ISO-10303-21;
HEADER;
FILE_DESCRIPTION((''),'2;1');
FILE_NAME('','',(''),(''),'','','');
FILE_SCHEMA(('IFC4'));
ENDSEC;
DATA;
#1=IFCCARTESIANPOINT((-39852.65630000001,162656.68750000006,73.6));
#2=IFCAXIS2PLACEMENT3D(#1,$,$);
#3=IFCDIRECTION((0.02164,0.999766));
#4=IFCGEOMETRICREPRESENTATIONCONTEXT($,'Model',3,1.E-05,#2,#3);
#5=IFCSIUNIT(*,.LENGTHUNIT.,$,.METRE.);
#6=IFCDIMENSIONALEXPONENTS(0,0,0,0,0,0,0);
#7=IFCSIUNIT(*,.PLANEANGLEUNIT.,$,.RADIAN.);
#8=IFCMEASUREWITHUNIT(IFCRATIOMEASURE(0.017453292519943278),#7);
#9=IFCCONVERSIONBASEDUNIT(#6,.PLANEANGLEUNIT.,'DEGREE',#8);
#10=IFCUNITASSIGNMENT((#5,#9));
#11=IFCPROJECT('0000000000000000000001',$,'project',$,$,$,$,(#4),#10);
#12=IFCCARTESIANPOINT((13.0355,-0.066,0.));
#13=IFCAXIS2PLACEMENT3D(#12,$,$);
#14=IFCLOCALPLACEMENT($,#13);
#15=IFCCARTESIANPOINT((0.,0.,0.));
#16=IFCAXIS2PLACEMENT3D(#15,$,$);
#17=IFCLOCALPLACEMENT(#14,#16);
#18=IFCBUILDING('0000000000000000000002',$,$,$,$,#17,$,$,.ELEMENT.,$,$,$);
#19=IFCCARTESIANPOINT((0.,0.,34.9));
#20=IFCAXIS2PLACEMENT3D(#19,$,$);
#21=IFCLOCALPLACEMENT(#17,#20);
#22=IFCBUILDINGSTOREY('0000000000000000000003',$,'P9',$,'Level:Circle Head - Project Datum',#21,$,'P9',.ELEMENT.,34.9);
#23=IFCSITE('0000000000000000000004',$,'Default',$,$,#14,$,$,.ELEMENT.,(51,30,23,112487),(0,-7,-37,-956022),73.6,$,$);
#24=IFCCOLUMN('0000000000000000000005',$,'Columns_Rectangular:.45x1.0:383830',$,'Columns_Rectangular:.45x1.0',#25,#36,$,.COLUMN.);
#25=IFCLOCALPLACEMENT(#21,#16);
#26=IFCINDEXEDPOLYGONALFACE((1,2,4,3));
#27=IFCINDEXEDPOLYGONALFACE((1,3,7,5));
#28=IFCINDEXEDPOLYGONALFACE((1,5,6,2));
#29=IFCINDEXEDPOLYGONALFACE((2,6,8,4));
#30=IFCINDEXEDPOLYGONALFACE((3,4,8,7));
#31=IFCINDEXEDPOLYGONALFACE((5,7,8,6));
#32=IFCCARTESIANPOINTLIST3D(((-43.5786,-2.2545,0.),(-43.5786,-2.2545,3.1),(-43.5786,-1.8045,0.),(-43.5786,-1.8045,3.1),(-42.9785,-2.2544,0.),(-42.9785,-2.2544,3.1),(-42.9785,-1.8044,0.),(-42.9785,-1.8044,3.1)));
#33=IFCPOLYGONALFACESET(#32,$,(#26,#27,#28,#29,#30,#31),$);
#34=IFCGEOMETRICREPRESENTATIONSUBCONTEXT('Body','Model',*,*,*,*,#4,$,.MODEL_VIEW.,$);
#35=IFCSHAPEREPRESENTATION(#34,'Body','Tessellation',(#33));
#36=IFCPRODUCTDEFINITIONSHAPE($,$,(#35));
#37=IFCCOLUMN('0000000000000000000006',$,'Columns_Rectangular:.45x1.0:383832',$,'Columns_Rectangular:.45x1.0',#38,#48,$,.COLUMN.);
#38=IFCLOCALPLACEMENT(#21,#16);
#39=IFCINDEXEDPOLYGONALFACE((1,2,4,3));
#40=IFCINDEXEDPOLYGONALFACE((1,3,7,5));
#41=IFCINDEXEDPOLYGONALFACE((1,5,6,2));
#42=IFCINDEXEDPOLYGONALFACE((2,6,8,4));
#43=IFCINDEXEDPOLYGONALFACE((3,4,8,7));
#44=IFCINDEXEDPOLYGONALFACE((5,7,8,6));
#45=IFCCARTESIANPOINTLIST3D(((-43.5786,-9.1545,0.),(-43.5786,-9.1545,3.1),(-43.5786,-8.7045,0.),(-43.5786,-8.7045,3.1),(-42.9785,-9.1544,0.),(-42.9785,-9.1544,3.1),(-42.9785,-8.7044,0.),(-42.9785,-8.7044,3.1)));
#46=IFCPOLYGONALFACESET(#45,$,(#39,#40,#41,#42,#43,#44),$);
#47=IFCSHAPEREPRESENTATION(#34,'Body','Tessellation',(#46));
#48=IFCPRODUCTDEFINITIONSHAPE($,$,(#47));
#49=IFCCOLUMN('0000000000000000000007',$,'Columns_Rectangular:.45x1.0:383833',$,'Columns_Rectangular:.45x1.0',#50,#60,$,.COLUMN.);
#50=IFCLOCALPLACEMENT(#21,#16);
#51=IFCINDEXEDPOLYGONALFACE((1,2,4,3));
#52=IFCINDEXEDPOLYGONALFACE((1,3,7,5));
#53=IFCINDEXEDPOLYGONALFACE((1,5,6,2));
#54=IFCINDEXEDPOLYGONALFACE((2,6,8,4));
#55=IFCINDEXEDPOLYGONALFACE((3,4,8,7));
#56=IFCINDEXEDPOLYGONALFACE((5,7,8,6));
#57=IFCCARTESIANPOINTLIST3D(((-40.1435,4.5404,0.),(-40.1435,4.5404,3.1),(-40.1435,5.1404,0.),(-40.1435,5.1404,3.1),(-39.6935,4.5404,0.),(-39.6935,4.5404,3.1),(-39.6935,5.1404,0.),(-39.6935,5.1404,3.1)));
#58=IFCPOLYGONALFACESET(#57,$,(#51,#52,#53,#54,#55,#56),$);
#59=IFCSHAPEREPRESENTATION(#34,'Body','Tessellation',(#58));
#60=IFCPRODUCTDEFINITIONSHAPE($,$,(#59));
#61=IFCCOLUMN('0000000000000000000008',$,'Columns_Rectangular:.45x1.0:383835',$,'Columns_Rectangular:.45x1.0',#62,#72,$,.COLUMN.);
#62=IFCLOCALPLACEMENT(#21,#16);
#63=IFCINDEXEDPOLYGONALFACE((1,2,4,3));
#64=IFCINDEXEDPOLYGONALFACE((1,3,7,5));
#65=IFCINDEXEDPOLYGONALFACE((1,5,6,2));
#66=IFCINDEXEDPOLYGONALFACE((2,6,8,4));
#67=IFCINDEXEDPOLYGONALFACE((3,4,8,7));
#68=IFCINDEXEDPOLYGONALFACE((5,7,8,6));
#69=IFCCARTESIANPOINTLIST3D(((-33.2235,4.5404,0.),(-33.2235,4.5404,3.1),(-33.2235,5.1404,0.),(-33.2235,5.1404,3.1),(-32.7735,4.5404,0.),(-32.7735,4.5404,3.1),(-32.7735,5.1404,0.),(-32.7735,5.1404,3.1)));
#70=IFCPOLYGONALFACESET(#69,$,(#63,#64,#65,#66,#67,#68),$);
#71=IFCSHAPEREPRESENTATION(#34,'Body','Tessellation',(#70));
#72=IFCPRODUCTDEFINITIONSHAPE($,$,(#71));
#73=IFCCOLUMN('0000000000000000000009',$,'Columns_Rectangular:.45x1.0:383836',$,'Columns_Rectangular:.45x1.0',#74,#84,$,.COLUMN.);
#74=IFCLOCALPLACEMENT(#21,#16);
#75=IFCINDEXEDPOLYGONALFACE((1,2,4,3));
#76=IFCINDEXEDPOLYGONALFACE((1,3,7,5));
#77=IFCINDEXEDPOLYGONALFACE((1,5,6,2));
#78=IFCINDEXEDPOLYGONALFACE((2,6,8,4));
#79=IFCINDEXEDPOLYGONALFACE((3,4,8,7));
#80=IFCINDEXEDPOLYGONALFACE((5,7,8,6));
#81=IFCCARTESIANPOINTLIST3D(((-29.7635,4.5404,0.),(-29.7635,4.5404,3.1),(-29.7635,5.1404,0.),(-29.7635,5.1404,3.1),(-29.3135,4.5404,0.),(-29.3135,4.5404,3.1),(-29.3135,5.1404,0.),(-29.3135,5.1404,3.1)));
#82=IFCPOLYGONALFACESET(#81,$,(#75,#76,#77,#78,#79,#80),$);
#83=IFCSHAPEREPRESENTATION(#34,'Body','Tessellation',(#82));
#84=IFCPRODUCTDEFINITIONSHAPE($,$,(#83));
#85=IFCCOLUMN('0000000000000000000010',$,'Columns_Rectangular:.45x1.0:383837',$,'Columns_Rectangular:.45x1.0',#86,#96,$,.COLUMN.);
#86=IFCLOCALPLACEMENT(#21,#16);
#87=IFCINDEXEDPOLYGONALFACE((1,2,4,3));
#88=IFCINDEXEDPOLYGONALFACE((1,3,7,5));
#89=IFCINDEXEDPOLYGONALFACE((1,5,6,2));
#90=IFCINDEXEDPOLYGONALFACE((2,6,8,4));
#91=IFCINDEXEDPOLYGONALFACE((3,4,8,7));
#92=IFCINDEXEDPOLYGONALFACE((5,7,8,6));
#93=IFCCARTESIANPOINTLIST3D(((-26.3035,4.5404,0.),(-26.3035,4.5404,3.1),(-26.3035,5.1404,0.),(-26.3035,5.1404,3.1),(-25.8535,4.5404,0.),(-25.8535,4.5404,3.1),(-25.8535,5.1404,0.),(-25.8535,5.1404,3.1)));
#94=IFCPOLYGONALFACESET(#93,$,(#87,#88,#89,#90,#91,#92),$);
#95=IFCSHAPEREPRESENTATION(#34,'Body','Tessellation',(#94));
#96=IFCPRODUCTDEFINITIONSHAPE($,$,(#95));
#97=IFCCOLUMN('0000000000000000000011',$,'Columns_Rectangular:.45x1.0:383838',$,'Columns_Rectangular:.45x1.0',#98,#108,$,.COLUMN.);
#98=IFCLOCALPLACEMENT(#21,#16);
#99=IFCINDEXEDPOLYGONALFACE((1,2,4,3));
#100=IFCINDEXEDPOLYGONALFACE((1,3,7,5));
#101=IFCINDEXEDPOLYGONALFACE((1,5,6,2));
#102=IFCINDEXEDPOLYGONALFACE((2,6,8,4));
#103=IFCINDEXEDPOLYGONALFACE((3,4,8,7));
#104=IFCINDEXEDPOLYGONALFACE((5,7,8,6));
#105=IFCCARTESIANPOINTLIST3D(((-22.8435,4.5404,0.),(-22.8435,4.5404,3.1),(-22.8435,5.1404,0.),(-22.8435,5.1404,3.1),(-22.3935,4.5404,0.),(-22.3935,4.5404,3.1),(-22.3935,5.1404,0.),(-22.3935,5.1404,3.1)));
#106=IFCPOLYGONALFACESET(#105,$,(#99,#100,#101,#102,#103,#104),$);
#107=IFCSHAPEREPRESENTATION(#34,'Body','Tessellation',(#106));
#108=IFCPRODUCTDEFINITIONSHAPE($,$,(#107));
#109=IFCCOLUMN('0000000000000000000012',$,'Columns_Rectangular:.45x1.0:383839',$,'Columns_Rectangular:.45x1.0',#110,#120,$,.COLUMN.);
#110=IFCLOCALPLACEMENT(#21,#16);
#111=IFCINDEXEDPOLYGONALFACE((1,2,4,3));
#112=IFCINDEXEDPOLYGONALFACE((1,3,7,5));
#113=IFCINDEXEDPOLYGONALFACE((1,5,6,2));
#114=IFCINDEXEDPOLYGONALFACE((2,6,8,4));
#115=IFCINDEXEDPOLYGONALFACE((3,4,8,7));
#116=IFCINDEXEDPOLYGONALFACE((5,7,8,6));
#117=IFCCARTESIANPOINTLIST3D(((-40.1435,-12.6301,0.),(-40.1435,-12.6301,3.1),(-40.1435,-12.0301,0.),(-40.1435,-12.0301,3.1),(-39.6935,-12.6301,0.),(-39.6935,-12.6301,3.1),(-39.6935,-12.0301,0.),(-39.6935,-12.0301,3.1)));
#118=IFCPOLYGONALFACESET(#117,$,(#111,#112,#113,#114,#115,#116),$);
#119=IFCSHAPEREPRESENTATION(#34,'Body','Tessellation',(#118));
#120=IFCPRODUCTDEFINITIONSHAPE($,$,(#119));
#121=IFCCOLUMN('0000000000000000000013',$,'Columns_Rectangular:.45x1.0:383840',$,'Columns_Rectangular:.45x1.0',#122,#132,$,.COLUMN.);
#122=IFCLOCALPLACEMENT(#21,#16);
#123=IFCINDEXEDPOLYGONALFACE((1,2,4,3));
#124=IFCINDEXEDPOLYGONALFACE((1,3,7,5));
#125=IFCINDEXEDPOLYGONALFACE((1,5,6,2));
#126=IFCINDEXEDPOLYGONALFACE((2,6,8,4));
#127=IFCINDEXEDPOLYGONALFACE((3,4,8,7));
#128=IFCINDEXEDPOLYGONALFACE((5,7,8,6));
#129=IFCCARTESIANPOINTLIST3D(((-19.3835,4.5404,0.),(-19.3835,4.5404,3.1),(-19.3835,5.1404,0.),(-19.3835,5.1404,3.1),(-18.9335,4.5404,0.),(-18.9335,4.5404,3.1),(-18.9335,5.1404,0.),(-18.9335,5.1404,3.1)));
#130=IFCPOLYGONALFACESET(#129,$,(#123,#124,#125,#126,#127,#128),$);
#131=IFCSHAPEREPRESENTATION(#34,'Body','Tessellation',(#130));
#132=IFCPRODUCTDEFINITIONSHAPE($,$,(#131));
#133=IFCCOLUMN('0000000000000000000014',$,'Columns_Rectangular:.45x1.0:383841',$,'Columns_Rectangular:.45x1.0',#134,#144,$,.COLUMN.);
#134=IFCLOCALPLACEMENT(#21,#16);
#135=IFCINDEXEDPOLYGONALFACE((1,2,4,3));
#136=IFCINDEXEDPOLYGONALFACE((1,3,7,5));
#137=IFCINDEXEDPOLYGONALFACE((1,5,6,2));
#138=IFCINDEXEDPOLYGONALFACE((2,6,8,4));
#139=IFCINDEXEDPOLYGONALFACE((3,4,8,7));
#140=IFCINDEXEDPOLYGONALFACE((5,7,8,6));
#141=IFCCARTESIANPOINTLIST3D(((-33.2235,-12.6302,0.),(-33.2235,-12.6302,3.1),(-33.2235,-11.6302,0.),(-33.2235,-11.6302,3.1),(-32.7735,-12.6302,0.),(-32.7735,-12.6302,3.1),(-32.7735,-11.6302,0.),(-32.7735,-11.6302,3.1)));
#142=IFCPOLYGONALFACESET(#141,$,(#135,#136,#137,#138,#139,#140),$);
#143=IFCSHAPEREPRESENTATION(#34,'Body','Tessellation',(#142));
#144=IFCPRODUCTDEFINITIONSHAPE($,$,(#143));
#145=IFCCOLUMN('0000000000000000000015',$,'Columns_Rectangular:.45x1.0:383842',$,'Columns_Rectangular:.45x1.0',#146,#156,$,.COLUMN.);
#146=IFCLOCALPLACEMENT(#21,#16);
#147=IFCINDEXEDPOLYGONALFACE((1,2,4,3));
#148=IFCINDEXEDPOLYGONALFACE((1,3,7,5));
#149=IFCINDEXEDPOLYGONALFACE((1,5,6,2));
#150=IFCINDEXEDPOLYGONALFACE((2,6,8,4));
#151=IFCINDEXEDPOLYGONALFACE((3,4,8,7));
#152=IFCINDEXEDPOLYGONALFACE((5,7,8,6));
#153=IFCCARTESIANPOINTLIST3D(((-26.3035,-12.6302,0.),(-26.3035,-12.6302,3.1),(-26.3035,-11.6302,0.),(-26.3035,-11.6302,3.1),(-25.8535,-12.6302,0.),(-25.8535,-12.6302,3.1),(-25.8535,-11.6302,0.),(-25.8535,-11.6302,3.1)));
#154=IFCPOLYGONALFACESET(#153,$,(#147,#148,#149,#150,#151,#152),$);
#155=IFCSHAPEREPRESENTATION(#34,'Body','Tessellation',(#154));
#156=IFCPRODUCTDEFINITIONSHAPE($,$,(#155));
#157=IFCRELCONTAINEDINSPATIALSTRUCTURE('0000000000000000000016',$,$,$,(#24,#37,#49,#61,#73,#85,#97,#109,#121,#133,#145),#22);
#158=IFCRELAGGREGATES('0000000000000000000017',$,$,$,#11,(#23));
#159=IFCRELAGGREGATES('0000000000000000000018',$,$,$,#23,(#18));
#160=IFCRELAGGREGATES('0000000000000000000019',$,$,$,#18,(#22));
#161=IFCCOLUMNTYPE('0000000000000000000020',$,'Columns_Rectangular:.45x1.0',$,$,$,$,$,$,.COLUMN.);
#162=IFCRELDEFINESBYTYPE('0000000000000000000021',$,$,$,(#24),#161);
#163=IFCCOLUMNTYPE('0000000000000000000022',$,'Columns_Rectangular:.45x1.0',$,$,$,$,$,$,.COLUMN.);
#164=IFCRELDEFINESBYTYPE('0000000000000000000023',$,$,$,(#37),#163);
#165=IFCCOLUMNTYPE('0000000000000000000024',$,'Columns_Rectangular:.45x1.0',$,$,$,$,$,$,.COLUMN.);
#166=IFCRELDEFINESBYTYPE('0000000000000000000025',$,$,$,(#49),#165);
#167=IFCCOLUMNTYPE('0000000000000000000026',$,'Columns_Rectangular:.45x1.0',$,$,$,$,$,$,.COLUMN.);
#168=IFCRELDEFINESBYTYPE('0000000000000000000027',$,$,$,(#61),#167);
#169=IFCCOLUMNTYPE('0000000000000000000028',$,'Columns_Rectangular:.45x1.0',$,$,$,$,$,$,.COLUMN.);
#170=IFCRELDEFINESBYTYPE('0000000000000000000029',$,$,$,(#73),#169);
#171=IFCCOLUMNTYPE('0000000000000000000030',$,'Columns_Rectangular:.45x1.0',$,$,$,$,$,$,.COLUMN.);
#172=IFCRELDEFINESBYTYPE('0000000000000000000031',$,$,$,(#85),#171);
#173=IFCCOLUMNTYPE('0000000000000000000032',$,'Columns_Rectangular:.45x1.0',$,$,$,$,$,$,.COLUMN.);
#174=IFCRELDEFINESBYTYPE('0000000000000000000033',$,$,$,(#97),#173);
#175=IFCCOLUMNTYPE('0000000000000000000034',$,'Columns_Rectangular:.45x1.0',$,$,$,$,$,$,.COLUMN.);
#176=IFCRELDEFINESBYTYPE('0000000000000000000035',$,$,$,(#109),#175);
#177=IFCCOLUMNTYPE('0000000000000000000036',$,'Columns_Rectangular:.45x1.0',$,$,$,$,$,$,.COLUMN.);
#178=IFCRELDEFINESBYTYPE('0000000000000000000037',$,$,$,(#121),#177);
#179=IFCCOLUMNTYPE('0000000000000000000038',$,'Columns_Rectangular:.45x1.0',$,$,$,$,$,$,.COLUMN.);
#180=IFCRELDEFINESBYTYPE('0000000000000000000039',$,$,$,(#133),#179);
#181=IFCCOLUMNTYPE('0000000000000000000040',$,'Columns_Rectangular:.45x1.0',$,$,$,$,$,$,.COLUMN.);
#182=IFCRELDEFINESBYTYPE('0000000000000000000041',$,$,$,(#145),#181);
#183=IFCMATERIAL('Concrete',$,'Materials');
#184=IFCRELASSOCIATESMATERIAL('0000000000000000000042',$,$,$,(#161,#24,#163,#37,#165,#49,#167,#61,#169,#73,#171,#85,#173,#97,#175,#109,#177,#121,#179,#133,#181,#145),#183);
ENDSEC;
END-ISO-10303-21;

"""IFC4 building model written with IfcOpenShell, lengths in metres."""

from ifc_helpers import new_model, entity, si_unit, converted_unit, direction, frame, origin, place, context, subcontext, project, spatial, indexed_curve, outline, extrude, source, transform, mapped, material, type_object, type_shapes, element, save


model = new_model("IFC4")

# Units and contexts
model_context = context("Model", 3, precision=1e-05, world=frame((-39852.65630000001, 162656.68750000006, 73.6)), true_north=direction((0.02164, 0.999766)))
body_context = subcontext(model_context, "Body", "Model", "MODEL_VIEW")
ifc_project = project(units=[si_unit("LENGTHUNIT", "METRE"), converted_unit("PLANEANGLEUNIT", "DEGREE", entity("IfcRatioMeasure", 0.017453292519943278), si_unit("PLANEANGLEUNIT", "RADIAN"), dimensions=[0, 0, 0, 0, 0, 0, 0])], contexts=[model_context])

# Site, building, storey
site_placement = place(None, frame((13.0355, -0.066, 0.0)))
site = spatial("IfcSite", under=ifc_project, at=site_placement, Name="Default", CompositionType="ELEMENT", RefLatitude=(51, 30, 23, 112487), RefLongitude=(0, -7, -37, -956022), RefElevation=73.6)
building_placement = place(site_placement, origin())
building = spatial("IfcBuilding", under=site, at=building_placement, CompositionType="ELEMENT")
storey_placement = place(building_placement, frame((0.0, 0.0, 34.9)))
storey = spatial("IfcBuildingStorey", under=building, at=storey_placement, Name="P9", ObjectType="Level:Circle Head - Project Datum", LongName="P9", CompositionType="ELEMENT", Elevation=34.9)

# Columns
ifc_material = material(Name="Concrete", Category="Materials")
column_type_1 = type_object("IfcColumnType", Name="Columns_Rectangular:.45x1.0", PredefinedType="COLUMN", material=ifc_material)
shared_shape_1 = source(origin(), body_context, "Body", "SweptSolid", [
    extrude(outline(indexed_curve([(-0.3, -0.225), (0.3, -0.225), (0.3, 0.225), (-0.3, 0.225), (-0.3, -0.225)], self_intersect=False)), frame((-43.2785, -2.0294, 34.9), z_axis=(0.0, 0.0, 1.0), x_axis=(-1.0, -0.000005, 0.0)), (0.0, 0.0, 1.0), 3.1),
])
type_shapes(column_type_1, [shared_shape_1])
column_1_placement = place(storey_placement, frame((0.0, 0.0, -34.9)))
element("IfcColumn", 1, at=column_1_placement, inside=storey, type_object=column_type_1, material=ifc_material, Name="Columns_Rectangular:.45x1.0:383830", ObjectType="Columns_Rectangular:.45x1.0", PredefinedType="COLUMN", context=body_context, shape_type="MappedRepresentation", body=[
    mapped(shared_shape_1, transform((0.0, 0.0, 0.0), scale=1.0)),
])
column_type_2 = type_object("IfcColumnType", Name="Columns_Rectangular:.45x1.0", PredefinedType="COLUMN", material=ifc_material)
shared_shape_2 = source(origin(), body_context, "Body", "SweptSolid", [
    extrude(outline(indexed_curve([(-0.3, -0.225), (0.3, -0.225), (0.3, 0.225), (-0.3, 0.225), (-0.3, -0.225)], self_intersect=False)), frame((-43.2785, -8.9294, 34.9), z_axis=(0.0, 0.0, 1.0), x_axis=(-1.0, -0.000005, 0.0)), (0.0, 0.0, 1.0), 3.1),
])
type_shapes(column_type_2, [shared_shape_2])
column_2_placement = place(storey_placement, frame((0.0, 0.0, -34.9)))
element("IfcColumn", 2, at=column_2_placement, inside=storey, type_object=column_type_2, material=ifc_material, Name="Columns_Rectangular:.45x1.0:383832", ObjectType="Columns_Rectangular:.45x1.0", PredefinedType="COLUMN", context=body_context, shape_type="MappedRepresentation", body=[
    mapped(shared_shape_2, transform((0.0, 0.0, 0.0), scale=1.0)),
])
column_type_3 = type_object("IfcColumnType", Name="Columns_Rectangular:.45x1.0", PredefinedType="COLUMN", material=ifc_material)
shared_shape_3 = source(origin(), body_context, "Body", "SweptSolid", [
    extrude(outline(indexed_curve([(-0.3, -0.225), (0.3, -0.225), (0.3, 0.225), (-0.3, 0.225), (-0.3, -0.225)], self_intersect=False)), frame((-39.9185, 4.8404, 34.9), z_axis=(0.0, 0.0, 1.0), x_axis=(0.0, -1.0, 0.0)), (0.0, 0.0, 1.0), 3.1),
])
type_shapes(column_type_3, [shared_shape_3])
column_3_placement = place(storey_placement, frame((0.0, 0.0, -34.9)))
element("IfcColumn", 3, at=column_3_placement, inside=storey, type_object=column_type_3, material=ifc_material, Name="Columns_Rectangular:.45x1.0:383833", ObjectType="Columns_Rectangular:.45x1.0", PredefinedType="COLUMN", context=body_context, shape_type="MappedRepresentation", body=[
    mapped(shared_shape_3, transform((0.0, 0.0, 0.0), scale=1.0)),
])
column_type_4 = type_object("IfcColumnType", Name="Columns_Rectangular:.45x1.0", PredefinedType="COLUMN", material=ifc_material)
shared_shape_4 = source(origin(), body_context, "Body", "SweptSolid", [
    extrude(outline(indexed_curve([(-0.3, -0.225), (0.3, -0.225), (0.3, 0.225), (-0.3, 0.225), (-0.3, -0.225)], self_intersect=False)), frame((-32.9985, 4.8404, 34.9), z_axis=(0.0, 0.0, 1.0), x_axis=(0.0, -1.0, 0.0)), (0.0, 0.0, 1.0), 3.1),
])
type_shapes(column_type_4, [shared_shape_4])
column_4_placement = place(storey_placement, frame((0.0, 0.0, -34.9)))
element("IfcColumn", 4, at=column_4_placement, inside=storey, type_object=column_type_4, material=ifc_material, Name="Columns_Rectangular:.45x1.0:383835", ObjectType="Columns_Rectangular:.45x1.0", PredefinedType="COLUMN", context=body_context, shape_type="MappedRepresentation", body=[
    mapped(shared_shape_4, transform((0.0, 0.0, 0.0), scale=1.0)),
])
column_type_5 = type_object("IfcColumnType", Name="Columns_Rectangular:.45x1.0", PredefinedType="COLUMN", material=ifc_material)
shared_shape_5 = source(origin(), body_context, "Body", "SweptSolid", [
    extrude(outline(indexed_curve([(-0.3, -0.225), (0.3, -0.225), (0.3, 0.225), (-0.3, 0.225), (-0.3, -0.225)], self_intersect=False)), frame((-29.5385, 4.8404, 34.9), z_axis=(0.0, 0.0, 1.0), x_axis=(0.0, -1.0, 0.0)), (0.0, 0.0, 1.0), 3.1),
])
type_shapes(column_type_5, [shared_shape_5])
column_5_placement = place(storey_placement, frame((0.0, 0.0, -34.9)))
element("IfcColumn", 5, at=column_5_placement, inside=storey, type_object=column_type_5, material=ifc_material, Name="Columns_Rectangular:.45x1.0:383836", ObjectType="Columns_Rectangular:.45x1.0", PredefinedType="COLUMN", context=body_context, shape_type="MappedRepresentation", body=[
    mapped(shared_shape_5, transform((0.0, 0.0, 0.0), scale=1.0)),
])
column_type_6 = type_object("IfcColumnType", Name="Columns_Rectangular:.45x1.0", PredefinedType="COLUMN", material=ifc_material)
shared_shape_6 = source(origin(), body_context, "Body", "SweptSolid", [
    extrude(outline(indexed_curve([(-0.3, -0.225), (0.3, -0.225), (0.3, 0.225), (-0.3, 0.225), (-0.3, -0.225)], self_intersect=False)), frame((-26.0785, 4.8404, 34.9), z_axis=(0.0, 0.0, 1.0), x_axis=(0.0, -1.0, 0.0)), (0.0, 0.0, 1.0), 3.1),
])
type_shapes(column_type_6, [shared_shape_6])
column_6_placement = place(storey_placement, frame((0.0, 0.0, -34.9)))
element("IfcColumn", 6, at=column_6_placement, inside=storey, type_object=column_type_6, material=ifc_material, Name="Columns_Rectangular:.45x1.0:383837", ObjectType="Columns_Rectangular:.45x1.0", PredefinedType="COLUMN", context=body_context, shape_type="MappedRepresentation", body=[
    mapped(shared_shape_6, transform((0.0, 0.0, 0.0), scale=1.0)),
])
column_type_7 = type_object("IfcColumnType", Name="Columns_Rectangular:.45x1.0", PredefinedType="COLUMN", material=ifc_material)
shared_shape_7 = source(origin(), body_context, "Body", "SweptSolid", [
    extrude(outline(indexed_curve([(-0.3, -0.225), (0.3, -0.225), (0.3, 0.225), (-0.3, 0.225), (-0.3, -0.225)], self_intersect=False)), frame((-22.6185, 4.8404, 34.9), z_axis=(0.0, 0.0, 1.0), x_axis=(0.0, -1.0, 0.0)), (0.0, 0.0, 1.0), 3.1),
])
type_shapes(column_type_7, [shared_shape_7])
column_7_placement = place(storey_placement, frame((0.0, 0.0, -34.9)))
element("IfcColumn", 7, at=column_7_placement, inside=storey, type_object=column_type_7, material=ifc_material, Name="Columns_Rectangular:.45x1.0:383838", ObjectType="Columns_Rectangular:.45x1.0", PredefinedType="COLUMN", context=body_context, shape_type="MappedRepresentation", body=[
    mapped(shared_shape_7, transform((0.0, 0.0, 0.0), scale=1.0)),
])
column_type_8 = type_object("IfcColumnType", Name="Columns_Rectangular:.45x1.0", PredefinedType="COLUMN", material=ifc_material)
shared_shape_8 = source(origin(), body_context, "Body", "SweptSolid", [
    extrude(outline(indexed_curve([(-0.3, -0.225), (0.3, -0.225), (0.3, 0.225), (-0.3, 0.225), (-0.3, -0.225)], self_intersect=False)), frame((-39.9185, -12.3301, 34.9), z_axis=(0.0, 0.0, 1.0), x_axis=(0.000011, 1.0, 0.0)), (0.0, 0.0, 1.0), 3.1),
])
type_shapes(column_type_8, [shared_shape_8])
column_8_placement = place(storey_placement, frame((0.0, 0.0, -34.9)))
element("IfcColumn", 8, at=column_8_placement, inside=storey, type_object=column_type_8, material=ifc_material, Name="Columns_Rectangular:.45x1.0:383839", ObjectType="Columns_Rectangular:.45x1.0", PredefinedType="COLUMN", context=body_context, shape_type="MappedRepresentation", body=[
    mapped(shared_shape_8, transform((0.0, 0.0, 0.0), scale=1.0)),
])
column_type_9 = type_object("IfcColumnType", Name="Columns_Rectangular:.45x1.0", PredefinedType="COLUMN", material=ifc_material)
shared_shape_9 = source(origin(), body_context, "Body", "SweptSolid", [
    extrude(outline(indexed_curve([(-0.3, -0.225), (0.3, -0.225), (0.3, 0.225), (-0.3, 0.225), (-0.3, -0.225)], self_intersect=False)), frame((-19.1585, 4.8404, 34.9), z_axis=(0.0, 0.0, 1.0), x_axis=(0.0, -1.0, 0.0)), (0.0, 0.0, 1.0), 3.1),
])
type_shapes(column_type_9, [shared_shape_9])
column_9_placement = place(storey_placement, frame((0.0, 0.0, -34.9)))
element("IfcColumn", 9, at=column_9_placement, inside=storey, type_object=column_type_9, material=ifc_material, Name="Columns_Rectangular:.45x1.0:383840", ObjectType="Columns_Rectangular:.45x1.0", PredefinedType="COLUMN", context=body_context, shape_type="MappedRepresentation", body=[
    mapped(shared_shape_9, transform((0.0, 0.0, 0.0), scale=1.0)),
])
column_type_10 = type_object("IfcColumnType", Name="Columns_Rectangular:.45x1.0", PredefinedType="COLUMN", material=ifc_material)
shared_shape_10 = source(origin(), body_context, "Body", "SweptSolid", [
    extrude(outline(indexed_curve([(-0.5, -0.225), (0.5, -0.225), (0.5, 0.225), (-0.5, 0.225), (-0.5, -0.225)], self_intersect=False)), frame((-32.9985, -12.1302, 34.9), z_axis=(0.0, 0.0, 1.0), x_axis=(0.000011, 1.0, 0.0)), (0.0, 0.0, 1.0), 3.1),
])
type_shapes(column_type_10, [shared_shape_10])
column_10_placement = place(storey_placement, frame((0.0, 0.0, -34.9)))
element("IfcColumn", 10, at=column_10_placement, inside=storey, type_object=column_type_10, material=ifc_material, Name="Columns_Rectangular:.45x1.0:383841", ObjectType="Columns_Rectangular:.45x1.0", PredefinedType="COLUMN", context=body_context, shape_type="MappedRepresentation", body=[
    mapped(shared_shape_10, transform((0.0, 0.0, 0.0), scale=1.0)),
])
column_type_11 = type_object("IfcColumnType", Name="Columns_Rectangular:.45x1.0", PredefinedType="COLUMN", material=ifc_material)
shared_shape_11 = source(origin(), body_context, "Body", "SweptSolid", [
    extrude(outline(indexed_curve([(-0.5, -0.225), (0.5, -0.225), (0.5, 0.225), (-0.5, 0.225), (-0.5, -0.225)], self_intersect=False)), frame((-26.0785, -12.1302, 34.9), z_axis=(0.0, 0.0, 1.0), x_axis=(0.000011, 1.0, 0.0)), (0.0, 0.0, 1.0), 3.1),
])
type_shapes(column_type_11, [shared_shape_11])
column_11_placement = place(storey_placement, frame((0.0, 0.0, -34.9)))
element("IfcColumn", 11, at=column_11_placement, inside=storey, type_object=column_type_11, material=ifc_material, Name="Columns_Rectangular:.45x1.0:383842", ObjectType="Columns_Rectangular:.45x1.0", PredefinedType="COLUMN", context=body_context, shape_type="MappedRepresentation", body=[
    mapped(shared_shape_11, transform((0.0, 0.0, 0.0), scale=1.0)),
])

save(model, "model.ifc")
